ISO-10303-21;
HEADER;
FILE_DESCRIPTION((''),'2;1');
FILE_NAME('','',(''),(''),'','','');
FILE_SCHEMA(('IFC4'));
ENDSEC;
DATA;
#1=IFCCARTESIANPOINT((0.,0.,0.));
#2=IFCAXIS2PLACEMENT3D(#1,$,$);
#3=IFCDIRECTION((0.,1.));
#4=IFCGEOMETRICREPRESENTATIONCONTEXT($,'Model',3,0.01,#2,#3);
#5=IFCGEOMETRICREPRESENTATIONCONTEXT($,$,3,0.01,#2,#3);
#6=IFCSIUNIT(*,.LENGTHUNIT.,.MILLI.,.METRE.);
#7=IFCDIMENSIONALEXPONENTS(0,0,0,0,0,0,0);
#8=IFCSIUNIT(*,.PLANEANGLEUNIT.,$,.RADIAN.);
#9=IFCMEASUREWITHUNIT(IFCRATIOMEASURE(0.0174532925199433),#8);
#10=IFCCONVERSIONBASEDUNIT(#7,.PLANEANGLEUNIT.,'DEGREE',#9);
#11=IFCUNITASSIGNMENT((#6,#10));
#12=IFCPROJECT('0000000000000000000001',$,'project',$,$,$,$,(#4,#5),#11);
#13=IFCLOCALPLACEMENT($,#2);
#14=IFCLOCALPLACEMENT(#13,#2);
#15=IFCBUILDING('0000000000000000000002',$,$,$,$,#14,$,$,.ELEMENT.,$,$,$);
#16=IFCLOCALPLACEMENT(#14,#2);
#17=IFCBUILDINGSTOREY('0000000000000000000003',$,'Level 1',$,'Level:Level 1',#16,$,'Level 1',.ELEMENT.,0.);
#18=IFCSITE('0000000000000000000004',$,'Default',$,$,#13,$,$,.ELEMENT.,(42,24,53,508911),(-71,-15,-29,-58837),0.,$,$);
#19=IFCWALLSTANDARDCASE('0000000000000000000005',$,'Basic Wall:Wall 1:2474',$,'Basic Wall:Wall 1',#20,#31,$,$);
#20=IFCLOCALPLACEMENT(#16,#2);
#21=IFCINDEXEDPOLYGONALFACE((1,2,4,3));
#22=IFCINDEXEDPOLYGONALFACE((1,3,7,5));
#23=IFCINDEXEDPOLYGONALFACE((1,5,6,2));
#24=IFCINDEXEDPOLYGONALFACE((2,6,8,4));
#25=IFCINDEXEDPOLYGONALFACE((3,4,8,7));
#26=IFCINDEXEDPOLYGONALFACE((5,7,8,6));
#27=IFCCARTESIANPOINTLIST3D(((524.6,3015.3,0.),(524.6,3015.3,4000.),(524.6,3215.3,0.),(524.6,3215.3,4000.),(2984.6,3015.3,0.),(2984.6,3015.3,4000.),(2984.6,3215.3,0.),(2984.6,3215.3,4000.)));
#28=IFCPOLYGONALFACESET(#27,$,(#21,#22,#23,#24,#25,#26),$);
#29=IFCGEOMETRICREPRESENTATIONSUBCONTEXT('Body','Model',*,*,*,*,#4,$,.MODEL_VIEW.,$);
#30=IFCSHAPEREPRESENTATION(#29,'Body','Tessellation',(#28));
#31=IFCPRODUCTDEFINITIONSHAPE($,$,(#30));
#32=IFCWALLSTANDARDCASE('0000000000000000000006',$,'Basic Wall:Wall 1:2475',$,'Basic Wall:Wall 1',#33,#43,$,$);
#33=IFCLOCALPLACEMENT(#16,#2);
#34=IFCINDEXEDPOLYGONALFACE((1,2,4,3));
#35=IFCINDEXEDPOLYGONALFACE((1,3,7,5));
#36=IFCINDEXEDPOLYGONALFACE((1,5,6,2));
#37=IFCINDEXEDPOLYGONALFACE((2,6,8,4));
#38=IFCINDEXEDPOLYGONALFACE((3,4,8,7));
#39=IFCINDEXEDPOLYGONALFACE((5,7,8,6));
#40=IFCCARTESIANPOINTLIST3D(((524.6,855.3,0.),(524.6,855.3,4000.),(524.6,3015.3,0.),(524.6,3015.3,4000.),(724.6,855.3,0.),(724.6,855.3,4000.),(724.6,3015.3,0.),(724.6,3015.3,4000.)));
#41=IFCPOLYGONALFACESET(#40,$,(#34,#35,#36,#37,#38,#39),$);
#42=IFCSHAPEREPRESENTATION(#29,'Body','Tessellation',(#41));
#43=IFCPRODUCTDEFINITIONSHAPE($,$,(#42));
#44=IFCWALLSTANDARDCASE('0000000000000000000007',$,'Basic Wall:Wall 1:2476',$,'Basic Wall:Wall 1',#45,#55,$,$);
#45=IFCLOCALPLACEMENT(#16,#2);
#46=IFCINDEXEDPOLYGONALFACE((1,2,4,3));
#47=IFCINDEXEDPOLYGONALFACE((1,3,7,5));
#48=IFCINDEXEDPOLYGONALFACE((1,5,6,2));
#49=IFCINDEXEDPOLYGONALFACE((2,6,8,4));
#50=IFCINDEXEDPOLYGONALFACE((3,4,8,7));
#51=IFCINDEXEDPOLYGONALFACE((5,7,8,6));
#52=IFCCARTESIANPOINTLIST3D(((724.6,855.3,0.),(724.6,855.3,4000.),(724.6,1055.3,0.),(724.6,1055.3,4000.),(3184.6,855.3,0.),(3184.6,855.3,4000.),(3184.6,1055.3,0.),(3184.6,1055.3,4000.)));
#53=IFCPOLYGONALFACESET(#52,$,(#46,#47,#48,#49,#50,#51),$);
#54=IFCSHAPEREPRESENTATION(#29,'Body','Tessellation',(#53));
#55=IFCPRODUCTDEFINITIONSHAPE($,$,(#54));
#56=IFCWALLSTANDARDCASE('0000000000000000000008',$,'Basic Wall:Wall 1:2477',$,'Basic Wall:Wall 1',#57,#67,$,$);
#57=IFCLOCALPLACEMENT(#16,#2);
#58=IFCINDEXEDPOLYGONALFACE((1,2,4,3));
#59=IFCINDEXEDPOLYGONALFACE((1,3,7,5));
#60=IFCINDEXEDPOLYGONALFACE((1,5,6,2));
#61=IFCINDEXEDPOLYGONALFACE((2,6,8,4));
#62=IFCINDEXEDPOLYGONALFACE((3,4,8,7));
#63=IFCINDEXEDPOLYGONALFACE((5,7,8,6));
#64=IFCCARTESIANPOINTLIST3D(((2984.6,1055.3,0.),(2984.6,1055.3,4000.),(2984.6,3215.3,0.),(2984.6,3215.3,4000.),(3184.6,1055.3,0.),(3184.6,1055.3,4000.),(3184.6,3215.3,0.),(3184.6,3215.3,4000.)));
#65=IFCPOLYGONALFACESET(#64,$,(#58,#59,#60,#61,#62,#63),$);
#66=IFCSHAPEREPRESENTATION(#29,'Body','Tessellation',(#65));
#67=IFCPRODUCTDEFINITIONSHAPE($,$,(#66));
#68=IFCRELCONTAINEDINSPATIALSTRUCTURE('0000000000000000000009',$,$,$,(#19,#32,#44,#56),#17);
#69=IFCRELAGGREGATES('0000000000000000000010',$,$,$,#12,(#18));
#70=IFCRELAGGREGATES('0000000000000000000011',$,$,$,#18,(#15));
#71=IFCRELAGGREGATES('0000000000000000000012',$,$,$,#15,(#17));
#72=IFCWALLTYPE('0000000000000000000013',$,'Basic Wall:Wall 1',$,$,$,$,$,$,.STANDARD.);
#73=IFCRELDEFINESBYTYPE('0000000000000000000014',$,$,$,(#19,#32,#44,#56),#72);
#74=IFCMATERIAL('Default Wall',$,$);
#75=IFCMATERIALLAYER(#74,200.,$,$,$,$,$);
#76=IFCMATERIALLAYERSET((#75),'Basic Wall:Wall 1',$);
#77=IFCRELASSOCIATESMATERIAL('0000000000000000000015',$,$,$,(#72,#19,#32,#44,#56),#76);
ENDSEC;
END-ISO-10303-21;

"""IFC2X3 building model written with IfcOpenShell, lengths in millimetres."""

from ifc_helpers import new_model, entity, si_unit, converted_unit, direction, frame, frame_2d, origin, place, context, subcontext, project, spatial, rectangle, extrude, material, layer, layer_set, layer_usage, type_object, element, save


model = new_model("IFC2X3")

# Units and contexts
model_context = context("Model", 3, precision=0.01, world=origin(), true_north=direction((0.0, 1.0)))
context_of_model = context(None, 3, precision=0.01, world=origin(), true_north=direction((0.0, 1.0)))
body_context = subcontext(model_context, "Body", "Model", "MODEL_VIEW")
ifc_project = project(units=[si_unit("LENGTHUNIT", "METRE", prefix="MILLI"), converted_unit("PLANEANGLEUNIT", "DEGREE", entity("IfcRatioMeasure", 0.0174532925199433), si_unit("PLANEANGLEUNIT", "RADIAN"), dimensions=[0, 0, 0, 0, 0, 0, 0])], contexts=[model_context, context_of_model])

# Site, building, storey
site_placement = place(None, origin())
site = spatial("IfcSite", under=ifc_project, at=site_placement, Name="Default", CompositionType="ELEMENT", RefLatitude=(42, 24, 53, 508911), RefLongitude=(-71, -15, -29, -58837), RefElevation=0.0)
building_placement = place(site_placement, origin())
building = spatial("IfcBuilding", under=site, at=building_placement, CompositionType="ELEMENT")
storey_placement = place(building_placement, origin())
storey = spatial("IfcBuildingStorey", under=building, at=storey_placement, Name="Level 1", ObjectType="Level:Level 1", LongName="Level 1", CompositionType="ELEMENT", Elevation=0.0)

# Walls
ifc_material = material(Name="Default Wall")
ifc_layer = layer(ifc_material, 200.0)
ifc_layer_set = layer_set([ifc_layer], Name="Basic Wall:Wall 1")
ifc_layer_usage_1 = layer_usage(ifc_layer_set, "AXIS2", "NEGATIVE", 100.0)
wall_type = type_object("IfcWallType", Name="Basic Wall:Wall 1", PredefinedType="STANDARD", material=ifc_layer_set)
wall_1_placement = place(storey_placement, frame((524.6, 3115.3, 0.0)))
element("IfcWallStandardCase", 1, at=wall_1_placement, inside=storey, type_object=wall_type, material=ifc_layer_usage_1, Name="Basic Wall:Wall 1:2474", ObjectType="Basic Wall:Wall 1", context=body_context, shape_type="SweptSolid", body=[
    extrude(rectangle(XDim=2460.0, YDim=200.0, at=frame_2d((1230.0, 0.0), x_axis=(-1.0, 0.0))), origin(), (0.0, 0.0, 1.0), 4000.0),
])
ifc_layer_usage_2 = layer_usage(ifc_layer_set, "AXIS2", "NEGATIVE", 100.0)
wall_2_placement = place(storey_placement, frame((624.6, 855.3, 0.0), z_axis=(0.0, 0.0, 1.0), x_axis=(0.0, 1.0, 0.0)))
element("IfcWallStandardCase", 2, at=wall_2_placement, inside=storey, type_object=wall_type, material=ifc_layer_usage_2, Name="Basic Wall:Wall 1:2475", ObjectType="Basic Wall:Wall 1", context=body_context, shape_type="SweptSolid", body=[
    extrude(rectangle(XDim=2160.0, YDim=200.0, at=frame_2d((1080.0, 0.0), x_axis=(-1.0, 0.0))), origin(), (0.0, 0.0, 1.0), 4000.0),
])
ifc_layer_usage_3 = layer_usage(ifc_layer_set, "AXIS2", "NEGATIVE", 100.0)
wall_3_placement = place(storey_placement, frame((3184.6, 955.3, 0.0), z_axis=(0.0, 0.0, 1.0), x_axis=(-1.0, 0.0, 0.0)))
element("IfcWallStandardCase", 3, at=wall_3_placement, inside=storey, type_object=wall_type, material=ifc_layer_usage_3, Name="Basic Wall:Wall 1:2476", ObjectType="Basic Wall:Wall 1", context=body_context, shape_type="SweptSolid", body=[
    extrude(rectangle(XDim=2460.0, YDim=200.0, at=frame_2d((1230.0, 0.0), x_axis=(-1.0, 0.0))), origin(), (0.0, 0.0, 1.0), 4000.0),
])
ifc_layer_usage_4 = layer_usage(ifc_layer_set, "AXIS2", "NEGATIVE", 100.0)
wall_4_placement = place(storey_placement, frame((3084.6, 3215.3, 0.0), z_axis=(0.0, 0.0, 1.0), x_axis=(0.0, -1.0, 0.0)))
element("IfcWallStandardCase", 4, at=wall_4_placement, inside=storey, type_object=wall_type, material=ifc_layer_usage_4, Name="Basic Wall:Wall 1:2477", ObjectType="Basic Wall:Wall 1", context=body_context, shape_type="SweptSolid", body=[
    extrude(rectangle(XDim=2160.0, YDim=200.0, at=frame_2d((1080.0, 0.0), x_axis=(-1.0, 0.0))), origin(), (0.0, 0.0, 1.0), 4000.0),
])

save(model, "model.ifc")
